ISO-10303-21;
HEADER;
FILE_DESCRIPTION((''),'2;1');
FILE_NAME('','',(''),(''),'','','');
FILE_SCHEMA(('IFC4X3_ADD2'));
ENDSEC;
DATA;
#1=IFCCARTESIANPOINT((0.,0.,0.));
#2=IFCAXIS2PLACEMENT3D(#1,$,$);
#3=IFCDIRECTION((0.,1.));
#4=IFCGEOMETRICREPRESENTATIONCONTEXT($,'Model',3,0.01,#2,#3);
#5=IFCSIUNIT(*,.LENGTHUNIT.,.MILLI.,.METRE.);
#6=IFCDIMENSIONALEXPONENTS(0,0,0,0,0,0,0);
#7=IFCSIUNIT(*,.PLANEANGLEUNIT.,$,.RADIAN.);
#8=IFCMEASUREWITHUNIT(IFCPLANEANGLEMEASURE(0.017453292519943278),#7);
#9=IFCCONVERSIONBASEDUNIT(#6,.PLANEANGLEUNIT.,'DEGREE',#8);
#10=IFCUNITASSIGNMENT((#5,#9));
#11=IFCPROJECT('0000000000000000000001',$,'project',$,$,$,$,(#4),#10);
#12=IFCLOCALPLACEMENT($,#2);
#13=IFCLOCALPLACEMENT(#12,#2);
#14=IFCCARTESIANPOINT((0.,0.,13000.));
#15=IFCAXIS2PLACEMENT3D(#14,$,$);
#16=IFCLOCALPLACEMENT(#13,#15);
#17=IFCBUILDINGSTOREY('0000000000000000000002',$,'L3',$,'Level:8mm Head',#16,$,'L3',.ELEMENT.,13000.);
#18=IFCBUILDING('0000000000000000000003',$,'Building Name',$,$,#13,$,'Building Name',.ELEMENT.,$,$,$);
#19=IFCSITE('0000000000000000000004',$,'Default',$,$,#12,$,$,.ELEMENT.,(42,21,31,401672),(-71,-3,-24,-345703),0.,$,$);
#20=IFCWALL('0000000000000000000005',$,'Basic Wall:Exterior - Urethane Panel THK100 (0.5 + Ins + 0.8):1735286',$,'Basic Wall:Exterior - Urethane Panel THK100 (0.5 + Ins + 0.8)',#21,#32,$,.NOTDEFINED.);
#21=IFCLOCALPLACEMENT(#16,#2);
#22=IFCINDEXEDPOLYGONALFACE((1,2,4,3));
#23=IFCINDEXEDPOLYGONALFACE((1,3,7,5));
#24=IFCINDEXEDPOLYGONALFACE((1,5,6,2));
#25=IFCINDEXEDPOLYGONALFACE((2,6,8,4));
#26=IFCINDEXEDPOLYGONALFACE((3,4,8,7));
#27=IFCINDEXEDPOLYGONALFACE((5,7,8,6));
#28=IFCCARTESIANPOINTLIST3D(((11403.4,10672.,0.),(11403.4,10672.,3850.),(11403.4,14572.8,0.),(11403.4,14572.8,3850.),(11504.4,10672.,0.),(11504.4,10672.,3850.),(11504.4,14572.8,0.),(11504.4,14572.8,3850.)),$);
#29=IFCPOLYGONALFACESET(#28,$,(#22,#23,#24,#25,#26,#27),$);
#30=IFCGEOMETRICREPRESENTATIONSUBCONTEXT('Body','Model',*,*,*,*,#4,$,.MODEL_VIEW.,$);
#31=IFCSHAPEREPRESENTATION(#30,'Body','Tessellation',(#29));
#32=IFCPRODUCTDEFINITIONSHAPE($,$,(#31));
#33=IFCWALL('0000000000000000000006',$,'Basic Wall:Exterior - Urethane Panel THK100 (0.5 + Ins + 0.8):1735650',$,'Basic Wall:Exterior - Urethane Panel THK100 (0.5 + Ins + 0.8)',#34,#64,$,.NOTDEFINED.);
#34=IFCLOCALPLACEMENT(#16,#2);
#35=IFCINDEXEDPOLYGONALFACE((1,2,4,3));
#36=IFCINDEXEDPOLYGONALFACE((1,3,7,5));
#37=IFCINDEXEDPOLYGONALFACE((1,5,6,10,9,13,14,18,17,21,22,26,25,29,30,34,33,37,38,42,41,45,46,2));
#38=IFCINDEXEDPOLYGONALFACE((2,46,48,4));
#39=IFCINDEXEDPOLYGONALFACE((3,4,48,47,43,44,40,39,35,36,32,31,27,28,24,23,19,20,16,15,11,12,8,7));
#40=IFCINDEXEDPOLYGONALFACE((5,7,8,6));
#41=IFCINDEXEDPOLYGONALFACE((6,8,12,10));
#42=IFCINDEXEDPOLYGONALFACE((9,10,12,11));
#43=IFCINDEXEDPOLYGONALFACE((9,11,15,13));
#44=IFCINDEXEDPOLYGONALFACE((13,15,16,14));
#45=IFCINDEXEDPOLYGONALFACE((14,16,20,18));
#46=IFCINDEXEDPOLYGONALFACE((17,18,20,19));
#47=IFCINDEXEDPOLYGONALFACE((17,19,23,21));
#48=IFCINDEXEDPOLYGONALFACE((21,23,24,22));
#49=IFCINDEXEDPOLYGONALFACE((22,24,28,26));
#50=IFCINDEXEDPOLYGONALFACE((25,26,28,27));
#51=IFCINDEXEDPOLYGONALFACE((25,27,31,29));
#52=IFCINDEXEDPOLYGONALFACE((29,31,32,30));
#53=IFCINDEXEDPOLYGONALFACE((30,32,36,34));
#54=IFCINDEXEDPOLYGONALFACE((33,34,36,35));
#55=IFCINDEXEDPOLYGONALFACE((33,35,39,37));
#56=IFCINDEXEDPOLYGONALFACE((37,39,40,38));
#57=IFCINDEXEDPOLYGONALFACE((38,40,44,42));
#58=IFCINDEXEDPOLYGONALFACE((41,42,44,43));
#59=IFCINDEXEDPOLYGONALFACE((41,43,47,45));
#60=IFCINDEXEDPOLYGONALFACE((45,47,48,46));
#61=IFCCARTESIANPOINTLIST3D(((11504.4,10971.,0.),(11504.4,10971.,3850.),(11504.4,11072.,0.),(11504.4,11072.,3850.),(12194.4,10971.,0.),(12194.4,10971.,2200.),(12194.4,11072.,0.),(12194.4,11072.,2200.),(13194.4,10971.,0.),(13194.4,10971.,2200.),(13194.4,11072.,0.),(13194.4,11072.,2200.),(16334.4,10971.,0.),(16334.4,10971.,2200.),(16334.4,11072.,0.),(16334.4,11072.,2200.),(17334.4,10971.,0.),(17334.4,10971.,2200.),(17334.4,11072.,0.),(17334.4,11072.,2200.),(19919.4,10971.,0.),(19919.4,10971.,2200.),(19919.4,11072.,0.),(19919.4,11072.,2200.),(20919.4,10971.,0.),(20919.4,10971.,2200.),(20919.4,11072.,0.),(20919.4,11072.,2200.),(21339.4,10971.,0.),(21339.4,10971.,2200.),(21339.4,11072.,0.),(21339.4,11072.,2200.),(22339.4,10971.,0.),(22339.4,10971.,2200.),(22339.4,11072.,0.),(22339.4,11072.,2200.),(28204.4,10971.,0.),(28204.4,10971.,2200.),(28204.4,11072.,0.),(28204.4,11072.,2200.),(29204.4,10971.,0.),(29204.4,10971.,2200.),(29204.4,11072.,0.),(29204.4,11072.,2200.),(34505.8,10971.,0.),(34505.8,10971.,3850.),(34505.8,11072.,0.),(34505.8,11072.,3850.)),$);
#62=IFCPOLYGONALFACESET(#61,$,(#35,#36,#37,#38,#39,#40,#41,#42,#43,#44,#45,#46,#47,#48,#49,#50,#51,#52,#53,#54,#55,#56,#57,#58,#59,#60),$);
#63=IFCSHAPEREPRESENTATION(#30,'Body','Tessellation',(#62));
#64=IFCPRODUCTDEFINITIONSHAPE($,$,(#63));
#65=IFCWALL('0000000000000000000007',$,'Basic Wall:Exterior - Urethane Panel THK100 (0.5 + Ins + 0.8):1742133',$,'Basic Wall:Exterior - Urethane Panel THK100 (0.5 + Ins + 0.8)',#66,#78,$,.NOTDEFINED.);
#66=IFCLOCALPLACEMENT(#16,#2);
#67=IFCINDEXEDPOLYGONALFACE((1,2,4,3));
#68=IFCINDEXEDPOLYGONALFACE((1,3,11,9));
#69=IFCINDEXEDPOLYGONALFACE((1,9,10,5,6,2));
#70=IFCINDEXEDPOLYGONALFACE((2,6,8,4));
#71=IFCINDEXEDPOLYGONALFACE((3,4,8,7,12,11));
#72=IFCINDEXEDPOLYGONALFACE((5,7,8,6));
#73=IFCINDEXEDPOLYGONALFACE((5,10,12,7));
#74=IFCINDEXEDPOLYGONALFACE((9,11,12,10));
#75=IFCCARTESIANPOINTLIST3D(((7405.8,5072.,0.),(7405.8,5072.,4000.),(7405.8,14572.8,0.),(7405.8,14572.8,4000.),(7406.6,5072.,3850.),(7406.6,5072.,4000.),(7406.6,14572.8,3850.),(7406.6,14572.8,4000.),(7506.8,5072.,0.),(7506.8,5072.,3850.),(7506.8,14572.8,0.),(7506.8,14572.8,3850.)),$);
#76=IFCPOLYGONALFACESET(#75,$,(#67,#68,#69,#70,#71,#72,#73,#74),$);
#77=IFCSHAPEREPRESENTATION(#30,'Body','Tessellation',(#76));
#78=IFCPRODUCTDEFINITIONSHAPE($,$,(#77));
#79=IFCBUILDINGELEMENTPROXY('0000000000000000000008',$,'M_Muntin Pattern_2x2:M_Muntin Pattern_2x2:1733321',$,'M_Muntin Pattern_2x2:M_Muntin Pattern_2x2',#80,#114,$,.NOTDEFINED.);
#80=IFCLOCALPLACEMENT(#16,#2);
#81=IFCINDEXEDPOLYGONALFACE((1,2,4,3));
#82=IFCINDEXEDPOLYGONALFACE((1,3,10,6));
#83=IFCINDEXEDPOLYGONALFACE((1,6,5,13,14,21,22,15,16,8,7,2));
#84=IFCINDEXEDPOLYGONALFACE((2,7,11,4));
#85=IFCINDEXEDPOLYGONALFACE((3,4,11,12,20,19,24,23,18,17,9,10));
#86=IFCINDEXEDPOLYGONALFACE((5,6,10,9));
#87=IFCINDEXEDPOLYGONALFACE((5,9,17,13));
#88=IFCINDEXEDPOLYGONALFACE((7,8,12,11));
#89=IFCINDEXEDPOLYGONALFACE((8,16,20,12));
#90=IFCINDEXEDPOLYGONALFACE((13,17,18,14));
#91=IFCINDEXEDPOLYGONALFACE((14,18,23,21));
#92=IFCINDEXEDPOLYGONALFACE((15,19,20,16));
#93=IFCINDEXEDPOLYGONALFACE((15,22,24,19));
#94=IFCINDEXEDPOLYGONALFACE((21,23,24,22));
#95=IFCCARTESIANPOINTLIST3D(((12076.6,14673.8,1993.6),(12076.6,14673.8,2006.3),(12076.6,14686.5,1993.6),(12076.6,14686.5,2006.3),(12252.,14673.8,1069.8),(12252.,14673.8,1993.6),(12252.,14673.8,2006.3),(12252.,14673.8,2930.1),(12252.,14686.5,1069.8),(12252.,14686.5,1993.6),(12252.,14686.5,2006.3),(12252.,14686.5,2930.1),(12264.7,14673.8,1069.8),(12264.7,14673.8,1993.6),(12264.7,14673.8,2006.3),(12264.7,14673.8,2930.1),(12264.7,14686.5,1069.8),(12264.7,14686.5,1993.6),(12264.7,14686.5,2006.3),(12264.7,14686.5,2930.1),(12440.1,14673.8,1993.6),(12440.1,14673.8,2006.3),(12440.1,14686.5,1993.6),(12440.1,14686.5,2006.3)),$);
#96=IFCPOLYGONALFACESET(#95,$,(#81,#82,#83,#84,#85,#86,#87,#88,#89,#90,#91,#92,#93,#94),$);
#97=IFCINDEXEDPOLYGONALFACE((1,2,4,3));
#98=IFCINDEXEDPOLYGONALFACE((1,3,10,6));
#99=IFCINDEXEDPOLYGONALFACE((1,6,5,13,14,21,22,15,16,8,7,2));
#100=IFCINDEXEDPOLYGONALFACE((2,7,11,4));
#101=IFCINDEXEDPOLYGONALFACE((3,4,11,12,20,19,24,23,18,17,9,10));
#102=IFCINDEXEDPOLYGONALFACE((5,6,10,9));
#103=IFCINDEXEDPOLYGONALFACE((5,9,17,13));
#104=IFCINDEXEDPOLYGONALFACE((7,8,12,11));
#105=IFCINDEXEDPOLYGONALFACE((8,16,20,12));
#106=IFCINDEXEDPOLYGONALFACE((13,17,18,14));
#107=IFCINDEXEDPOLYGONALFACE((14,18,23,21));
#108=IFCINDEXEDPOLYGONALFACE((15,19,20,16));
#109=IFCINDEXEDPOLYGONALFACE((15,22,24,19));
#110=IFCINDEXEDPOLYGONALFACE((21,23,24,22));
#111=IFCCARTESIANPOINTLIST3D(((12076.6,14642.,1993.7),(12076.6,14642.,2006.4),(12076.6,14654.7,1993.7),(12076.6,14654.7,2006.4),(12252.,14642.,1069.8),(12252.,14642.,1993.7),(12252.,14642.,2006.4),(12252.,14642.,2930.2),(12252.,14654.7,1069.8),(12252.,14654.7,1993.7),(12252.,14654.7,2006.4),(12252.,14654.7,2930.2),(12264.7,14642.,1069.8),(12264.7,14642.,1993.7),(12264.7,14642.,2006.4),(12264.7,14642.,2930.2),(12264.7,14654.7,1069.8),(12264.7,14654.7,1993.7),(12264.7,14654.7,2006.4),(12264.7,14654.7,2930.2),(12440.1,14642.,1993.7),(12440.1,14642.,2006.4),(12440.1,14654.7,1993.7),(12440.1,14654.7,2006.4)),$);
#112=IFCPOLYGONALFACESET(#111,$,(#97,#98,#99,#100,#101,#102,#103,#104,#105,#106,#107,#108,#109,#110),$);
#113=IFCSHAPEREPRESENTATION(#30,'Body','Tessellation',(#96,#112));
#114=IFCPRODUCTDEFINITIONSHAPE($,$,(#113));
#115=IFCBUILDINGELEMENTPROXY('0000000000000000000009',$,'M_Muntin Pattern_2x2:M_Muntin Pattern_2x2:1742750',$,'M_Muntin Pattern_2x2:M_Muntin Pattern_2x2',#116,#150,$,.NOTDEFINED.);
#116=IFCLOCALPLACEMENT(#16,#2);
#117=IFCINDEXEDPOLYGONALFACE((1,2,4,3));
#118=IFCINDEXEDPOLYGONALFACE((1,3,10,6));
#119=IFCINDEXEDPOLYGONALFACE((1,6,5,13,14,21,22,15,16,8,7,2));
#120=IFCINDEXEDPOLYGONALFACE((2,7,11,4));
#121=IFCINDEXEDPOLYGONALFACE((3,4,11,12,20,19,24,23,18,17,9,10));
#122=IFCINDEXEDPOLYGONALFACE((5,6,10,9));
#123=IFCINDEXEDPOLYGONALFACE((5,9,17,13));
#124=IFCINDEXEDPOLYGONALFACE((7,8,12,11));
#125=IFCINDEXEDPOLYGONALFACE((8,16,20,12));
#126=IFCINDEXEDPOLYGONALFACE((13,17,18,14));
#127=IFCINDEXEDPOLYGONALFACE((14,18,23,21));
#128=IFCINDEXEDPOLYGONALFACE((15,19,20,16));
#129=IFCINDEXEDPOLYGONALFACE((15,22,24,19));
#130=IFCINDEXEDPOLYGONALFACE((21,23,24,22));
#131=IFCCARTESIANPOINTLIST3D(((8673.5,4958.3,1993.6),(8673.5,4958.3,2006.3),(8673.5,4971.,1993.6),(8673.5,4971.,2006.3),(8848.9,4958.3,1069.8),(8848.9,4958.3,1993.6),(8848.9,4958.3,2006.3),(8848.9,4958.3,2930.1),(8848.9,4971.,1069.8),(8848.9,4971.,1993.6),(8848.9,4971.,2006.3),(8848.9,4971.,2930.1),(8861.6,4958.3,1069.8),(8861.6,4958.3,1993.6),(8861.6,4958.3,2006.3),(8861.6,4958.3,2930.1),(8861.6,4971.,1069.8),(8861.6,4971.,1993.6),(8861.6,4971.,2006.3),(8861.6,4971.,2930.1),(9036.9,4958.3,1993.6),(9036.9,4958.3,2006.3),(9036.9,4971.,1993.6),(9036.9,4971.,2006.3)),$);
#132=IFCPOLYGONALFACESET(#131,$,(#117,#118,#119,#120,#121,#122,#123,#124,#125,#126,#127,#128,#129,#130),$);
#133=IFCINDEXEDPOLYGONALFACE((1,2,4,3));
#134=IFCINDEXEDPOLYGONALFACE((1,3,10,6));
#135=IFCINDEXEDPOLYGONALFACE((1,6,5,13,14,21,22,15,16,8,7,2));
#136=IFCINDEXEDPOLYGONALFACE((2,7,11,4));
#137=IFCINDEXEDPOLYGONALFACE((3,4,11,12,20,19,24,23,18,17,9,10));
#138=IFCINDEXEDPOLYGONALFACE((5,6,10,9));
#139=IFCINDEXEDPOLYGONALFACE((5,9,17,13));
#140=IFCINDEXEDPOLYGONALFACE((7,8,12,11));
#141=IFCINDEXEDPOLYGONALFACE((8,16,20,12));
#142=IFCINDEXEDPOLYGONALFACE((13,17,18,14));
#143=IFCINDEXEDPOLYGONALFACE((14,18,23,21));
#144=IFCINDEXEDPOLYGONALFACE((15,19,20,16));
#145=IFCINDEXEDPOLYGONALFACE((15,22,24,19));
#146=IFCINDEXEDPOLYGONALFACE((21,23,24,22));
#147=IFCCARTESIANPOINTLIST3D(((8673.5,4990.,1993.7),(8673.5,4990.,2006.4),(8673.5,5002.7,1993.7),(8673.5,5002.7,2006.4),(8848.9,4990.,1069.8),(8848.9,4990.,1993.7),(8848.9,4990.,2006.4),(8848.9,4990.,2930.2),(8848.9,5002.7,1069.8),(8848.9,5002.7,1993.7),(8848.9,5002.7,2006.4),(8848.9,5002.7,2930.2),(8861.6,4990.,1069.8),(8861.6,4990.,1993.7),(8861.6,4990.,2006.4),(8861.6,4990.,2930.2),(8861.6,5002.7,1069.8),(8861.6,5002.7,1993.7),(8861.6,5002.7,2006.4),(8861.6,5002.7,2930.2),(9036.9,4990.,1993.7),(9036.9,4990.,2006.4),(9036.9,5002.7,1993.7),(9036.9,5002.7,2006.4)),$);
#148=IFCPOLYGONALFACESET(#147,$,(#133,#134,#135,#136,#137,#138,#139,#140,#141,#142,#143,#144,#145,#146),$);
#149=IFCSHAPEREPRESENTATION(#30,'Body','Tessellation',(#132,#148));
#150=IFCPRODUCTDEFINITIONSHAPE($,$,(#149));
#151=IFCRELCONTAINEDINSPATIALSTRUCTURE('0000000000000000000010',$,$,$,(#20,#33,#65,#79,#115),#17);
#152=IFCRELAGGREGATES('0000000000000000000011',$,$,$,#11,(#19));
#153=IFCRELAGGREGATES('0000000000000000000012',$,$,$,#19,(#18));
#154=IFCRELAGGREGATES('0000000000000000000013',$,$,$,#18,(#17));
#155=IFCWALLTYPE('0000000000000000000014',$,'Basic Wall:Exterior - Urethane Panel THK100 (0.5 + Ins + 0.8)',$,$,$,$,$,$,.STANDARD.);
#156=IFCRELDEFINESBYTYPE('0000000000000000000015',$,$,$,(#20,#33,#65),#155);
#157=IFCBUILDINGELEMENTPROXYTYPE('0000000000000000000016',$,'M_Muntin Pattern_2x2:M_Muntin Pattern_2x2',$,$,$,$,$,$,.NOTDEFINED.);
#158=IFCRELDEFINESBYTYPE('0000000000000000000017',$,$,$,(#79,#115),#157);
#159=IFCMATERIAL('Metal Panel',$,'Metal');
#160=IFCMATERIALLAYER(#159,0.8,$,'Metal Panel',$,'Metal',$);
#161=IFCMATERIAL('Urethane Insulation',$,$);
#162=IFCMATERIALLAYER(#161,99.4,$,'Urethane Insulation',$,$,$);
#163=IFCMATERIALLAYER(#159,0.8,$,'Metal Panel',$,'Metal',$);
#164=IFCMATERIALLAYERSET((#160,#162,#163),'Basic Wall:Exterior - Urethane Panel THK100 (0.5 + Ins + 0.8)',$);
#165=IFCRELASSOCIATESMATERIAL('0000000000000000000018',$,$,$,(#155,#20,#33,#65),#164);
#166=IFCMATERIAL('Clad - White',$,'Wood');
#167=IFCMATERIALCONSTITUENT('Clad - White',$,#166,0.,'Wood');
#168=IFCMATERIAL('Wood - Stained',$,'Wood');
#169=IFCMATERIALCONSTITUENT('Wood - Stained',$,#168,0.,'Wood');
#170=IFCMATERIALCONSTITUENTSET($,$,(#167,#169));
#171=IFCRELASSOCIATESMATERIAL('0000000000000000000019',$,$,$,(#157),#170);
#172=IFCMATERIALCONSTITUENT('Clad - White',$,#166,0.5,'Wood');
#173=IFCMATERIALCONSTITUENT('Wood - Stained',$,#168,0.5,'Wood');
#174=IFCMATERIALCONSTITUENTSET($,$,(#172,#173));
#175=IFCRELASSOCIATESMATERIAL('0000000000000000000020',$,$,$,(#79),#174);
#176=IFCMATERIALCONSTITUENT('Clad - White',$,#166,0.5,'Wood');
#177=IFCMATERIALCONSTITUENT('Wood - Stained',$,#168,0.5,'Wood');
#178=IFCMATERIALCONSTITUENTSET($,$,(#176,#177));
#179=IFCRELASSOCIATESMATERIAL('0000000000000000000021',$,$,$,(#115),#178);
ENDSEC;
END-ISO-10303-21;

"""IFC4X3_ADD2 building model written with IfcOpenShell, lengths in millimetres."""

from ifc_helpers import new_model, entity, si_unit, converted_unit, direction, frame, frame_2d, origin, place, context, subcontext, project, spatial, polyline, rectangle, outline, extrude, clip, bounded_halfspace, source, transform, mapped, material, layer, layer_set, constituent, constituent_set, type_object, type_shapes, element, save


model = new_model("IFC4X3_ADD2")

# Units and contexts
model_context = context("Model", 3, precision=0.01, world=origin(), true_north=direction((0.0, 1.0)))
body_context = subcontext(model_context, "Body", "Model", "MODEL_VIEW")
ifc_project = project(units=[si_unit("LENGTHUNIT", "METRE", prefix="MILLI"), converted_unit("PLANEANGLEUNIT", "DEGREE", entity("IfcPlaneAngleMeasure", 0.017453292519943278), si_unit("PLANEANGLEUNIT", "RADIAN"), dimensions=[0, 0, 0, 0, 0, 0, 0])], contexts=[model_context])

# Site, building, storey
site_placement = place(None, origin())
site = spatial("IfcSite", under=ifc_project, at=site_placement, Name="Default", CompositionType="ELEMENT", RefLatitude=(42, 21, 31, 401672), RefLongitude=(-71, -3, -24, -345703), RefElevation=0.0)
building_placement = place(site_placement, origin())
building = spatial("IfcBuilding", under=site, at=building_placement, Name="Building Name", LongName="Building Name", CompositionType="ELEMENT")
storey_placement = place(building_placement, frame((0.0, 0.0, 13000.0)))
storey = spatial("IfcBuildingStorey", under=building, at=storey_placement, Name="L3", ObjectType="Level:8mm Head", LongName="L3", CompositionType="ELEMENT", Elevation=13000.0)

# Shared definitions
ifc_material_1 = material(Name="Metal Panel", Category="Metal")
ifc_layer_1 = layer(ifc_material_1, 0.8, Name="Metal Panel", Category="Metal")
ifc_material_2 = material(Name="Urethane Insulation")
ifc_layer_2 = layer(ifc_material_2, 99.4, Name="Urethane Insulation")
ifc_layer_3 = layer(ifc_material_1, 0.8, Name="Metal Panel", Category="Metal")
ifc_layer_set_1 = layer_set([ifc_layer_1, ifc_layer_2, ifc_layer_3], Name="Basic Wall:Exterior - Urethane Panel THK100 (0.5 + Ins + 0.8)")
wall_type = type_object("IfcWallType", Name="Basic Wall:Exterior - Urethane Panel THK100 (0.5 + Ins + 0.8)", PredefinedType="STANDARD", material=ifc_layer_set_1)

# Wall
wall_1_placement = place(storey_placement, frame((11453.9, 10672.0, 0.0), z_axis=(0.0, 0.0, 1.0), x_axis=(0.0, 1.0, 0.0)))
element("IfcWall", 1, at=wall_1_placement, inside=storey, type_object=wall_type, material=ifc_layer_set_1, Name="Basic Wall:Exterior - Urethane Panel THK100 (0.5 + Ins + 0.8):1735286", ObjectType="Basic Wall:Exterior - Urethane Panel THK100 (0.5 + Ins + 0.8)", PredefinedType="NOTDEFINED", context=body_context, shape_type="Clipping", body=[
    clip(extrude(rectangle(XDim=3900.8, YDim=101.0, at=frame_2d((1950.4, 0.0), x_axis=(-1.0, 0.0))), origin(), (0.0, 0.0, 1.0), 3850.0), bounded_halfspace(frame((0.0, -50.5, 3850.0), z_axis=(0.0, 0.0, -1.0), x_axis=(1.0, 0.0, 0.0)), True, frame((0.0, -50.5, 3850.0)), polyline([(0.0, 0.0), (299.0, 0.0), (400.0, 0.0), (3900.8, 0.0), (3900.8, 101.0), (0.0, 101.0), (0.0, 0.0)]))),
])

# Wall, openings
wall_2_placement = place(storey_placement, frame((11504.4, 11021.5, 0.0)))
wall_2 = element("IfcWall", 2, at=wall_2_placement, inside=storey, type_object=wall_type, material=ifc_layer_set_1, Name="Basic Wall:Exterior - Urethane Panel THK100 (0.5 + Ins + 0.8):1735650", ObjectType="Basic Wall:Exterior - Urethane Panel THK100 (0.5 + Ins + 0.8)", PredefinedType="NOTDEFINED", context=body_context, shape_type="Clipping", body=[
    clip(extrude(rectangle(XDim=23001.4, YDim=101.0, at=frame_2d((11500.7, 0.0), x_axis=(1.0, 0.0))), origin(), (0.0, 0.0, 1.0), 3850.0), bounded_halfspace(frame((0.0, -50.5, 3850.0), z_axis=(0.0, 0.0, -1.0), x_axis=(0.0, 1.0, 0.0)), True, frame((0.0, -50.5, 3850.0)), polyline([(0.0, 0.0), (18999.0, 0.0), (19100.0, 0.0), (23001.4, 0.0), (23001.4, 101.0), (16600.0, 101.0), (16499.0, 101.0), (9635.0, 101.0), (9534.0, 101.0), (7950.0, 101.0), (7849.0, 101.0), (6050.0, 101.0), (5949.0, 101.0), (2500.0, 101.0), (2399.0, 101.0), (0.0, 101.0), (0.0, 0.0)]))),
])
opening_1_placement = place(wall_2_placement, frame((690.0, -50.5, 0.0)))
element("IfcOpeningElement", 3, at=opening_1_placement, cuts=wall_2, PredefinedType="OPENING", context=body_context, shape_type="SweptSolid", body=[
    extrude(rectangle(XDim=2200.0, YDim=1000.0, at=frame_2d((1100.0, 500.0), x_axis=(1.0, 0.0))), frame((0.0, 0.0, 0.0), z_axis=(0.0, 1.0, 0.0), x_axis=(0.0, 0.0, 1.0)), (0.0, 0.0, 1.0), 101.0),
])
opening_2_placement = place(wall_2_placement, frame((4830.0, -50.5, 0.0)))
element("IfcOpeningElement", 4, at=opening_2_placement, cuts=wall_2, PredefinedType="OPENING", context=body_context, shape_type="SweptSolid", body=[
    extrude(rectangle(XDim=2200.0, YDim=1000.0, at=frame_2d((1100.0, 500.0), x_axis=(1.0, 0.0))), frame((0.0, 0.0, 0.0), z_axis=(0.0, 1.0, 0.0), x_axis=(0.0, 0.0, 1.0)), (0.0, 0.0, 1.0), 101.0),
])
opening_3_placement = place(wall_2_placement, frame((8414.9, -50.5, 0.0)))
element("IfcOpeningElement", 5, at=opening_3_placement, cuts=wall_2, PredefinedType="OPENING", context=body_context, shape_type="SweptSolid", body=[
    extrude(rectangle(XDim=2200.0, YDim=1000.0, at=frame_2d((1100.0, 500.0), x_axis=(1.0, 0.0))), frame((0.0, 0.0, 0.0), z_axis=(0.0, 1.0, 0.0), x_axis=(0.0, 0.0, 1.0)), (0.0, 0.0, 1.0), 101.0),
])
opening_4_placement = place(wall_2_placement, frame((9835.0, -50.5, 0.0)))
element("IfcOpeningElement", 6, at=opening_4_placement, cuts=wall_2, PredefinedType="OPENING", context=body_context, shape_type="SweptSolid", body=[
    extrude(rectangle(XDim=2200.0, YDim=1000.0, at=frame_2d((1100.0, 500.0), x_axis=(1.0, 0.0))), frame((0.0, 0.0, 0.0), z_axis=(0.0, 1.0, 0.0), x_axis=(0.0, 0.0, 1.0)), (0.0, 0.0, 1.0), 101.0),
])
opening_5_placement = place(wall_2_placement, frame((16700.0, -50.5, 0.0)))
element("IfcOpeningElement", 7, at=opening_5_placement, cuts=wall_2, PredefinedType="OPENING", context=body_context, shape_type="SweptSolid", body=[
    extrude(rectangle(XDim=2200.0, YDim=1000.0, at=frame_2d((1100.0, 500.0), x_axis=(1.0, 0.0))), frame((0.0, 0.0, 0.0), z_axis=(0.0, 1.0, 0.0), x_axis=(0.0, 0.0, 1.0)), (0.0, 0.0, 1.0), 101.0),
])

# Wall
wall_3_placement = place(storey_placement, frame((7456.3, 14572.8, 0.0), z_axis=(0.0, 0.0, 1.0), x_axis=(0.0, -1.0, 0.0)))
element("IfcWall", 8, at=wall_3_placement, inside=storey, type_object=wall_type, material=ifc_layer_set_1, Name="Basic Wall:Exterior - Urethane Panel THK100 (0.5 + Ins + 0.8):1742133", ObjectType="Basic Wall:Exterior - Urethane Panel THK100 (0.5 + Ins + 0.8)", PredefinedType="NOTDEFINED", context=body_context, shape_type="Clipping", body=[
    clip(extrude(rectangle(XDim=9500.8, YDim=101.0, at=frame_2d((4750.4, 0.0), x_axis=(-1.0, 0.0))), origin(), (0.0, 0.0, 1.0), 4000.0), bounded_halfspace(frame((9500.8, -49.7, 3850.0), z_axis=(0.0, 0.0, -1.0), x_axis=(-1.0, 0.0, 0.0)), True, frame((9500.8, -49.7, 3850.0)), polyline([(0.0, 0.0), (0.0, 100.2), (-5499.0, 100.2), (-5600.0, 100.2), (-9500.8, 100.2), (-9500.8, 0.0), (0.0, 0.0)]))),
])

# Building element proxies
ifc_material_3 = material(Name="Clad - White", Category="Wood")
ifc_constituent_1 = constituent(ifc_material_3, Name="Clad - White", Category="Wood", fraction=0.5)
ifc_material_4 = material(Name="Wood - Stained", Category="Wood")
ifc_constituent_2 = constituent(ifc_material_4, Name="Wood - Stained", Category="Wood", fraction=0.5)
ifc_constituent_set_1 = constituent_set(constituents=[ifc_constituent_1, ifc_constituent_2])
ifc_constituent_3 = constituent(ifc_material_3, Name="Clad - White", Category="Wood", fraction=0.0)
ifc_constituent_4 = constituent(ifc_material_4, Name="Wood - Stained", Category="Wood", fraction=0.0)
ifc_constituent_set_2 = constituent_set(constituents=[ifc_constituent_3, ifc_constituent_4])
building_element_proxy_type_1 = type_object("IfcBuildingElementProxyType", Name="M_Muntin Pattern_2x2:M_Muntin Pattern_2x2", PredefinedType="NOTDEFINED", material=ifc_constituent_set_2)
shared_shape_1 = source(origin(), body_context, "Body", "SweptSolid", [
    extrude(outline(polyline([(6.4, -6.4), (930.1, -6.4), (930.1, 6.3), (6.4, 6.3), (6.4, 181.7), (-6.3, 181.7), (-6.3, 6.3), (-930.2, 6.3), (-930.2, -6.4), (-6.3, -6.4), (-6.3, -181.7), (6.4, -181.7), (6.4, -6.4)])), frame((0.0, 9.5, 930.1), z_axis=(0.0, 1.0, 0.0), x_axis=(0.0, 0.0, 1.0)), (0.0, 0.0, 1.0), 12.7),
    extrude(outline(polyline([(6.4, -6.4), (930.2, -6.4), (930.2, 6.3), (6.4, 6.3), (6.4, 181.7), (-6.3, 181.7), (-6.3, 6.3), (-930.2, 6.3), (-930.2, -6.4), (-6.3, -6.4), (-6.3, -181.7), (6.4, -181.7), (6.4, -6.4)])), frame((0.0, -22.2, 930.2), z_axis=(0.0, 1.0, 0.0), x_axis=(0.0, 0.0, 1.0)), (0.0, 0.0, 1.0), 12.7),
])
type_shapes(building_element_proxy_type_1, [shared_shape_1])
proxy_1_placement = place(storey_placement, frame((12258.4, 14664.3, 1069.8)))
element("IfcBuildingElementProxy", 9, at=proxy_1_placement, inside=storey, type_object=building_element_proxy_type_1, material=ifc_constituent_set_1, Name="M_Muntin Pattern_2x2:M_Muntin Pattern_2x2:1733321", ObjectType="M_Muntin Pattern_2x2:M_Muntin Pattern_2x2", PredefinedType="NOTDEFINED", context=body_context, shape_type="MappedRepresentation", body=[
    mapped(shared_shape_1, transform((0.0, 0.0, 0.0), scale=1.0)),
])
ifc_constituent_5 = constituent(ifc_material_3, Name="Clad - White", Category="Wood", fraction=0.5)
ifc_constituent_6 = constituent(ifc_material_4, Name="Wood - Stained", Category="Wood", fraction=0.5)
ifc_constituent_set_3 = constituent_set(constituents=[ifc_constituent_5, ifc_constituent_6])
proxy_2_placement = place(storey_placement, frame((8855.2, 4980.5, 1069.8), z_axis=(0.0, 0.0, 1.0), x_axis=(-1.0, 0.0, 0.0)))
element("IfcBuildingElementProxy", 10, at=proxy_2_placement, inside=storey, type_object=building_element_proxy_type_1, material=ifc_constituent_set_3, Name="M_Muntin Pattern_2x2:M_Muntin Pattern_2x2:1742750", ObjectType="M_Muntin Pattern_2x2:M_Muntin Pattern_2x2", PredefinedType="NOTDEFINED", context=body_context, shape_type="MappedRepresentation", body=[
    mapped(shared_shape_1, transform((0.0, 0.0, 0.0), scale=1.0)),
])

save(model, "model.ifc")
